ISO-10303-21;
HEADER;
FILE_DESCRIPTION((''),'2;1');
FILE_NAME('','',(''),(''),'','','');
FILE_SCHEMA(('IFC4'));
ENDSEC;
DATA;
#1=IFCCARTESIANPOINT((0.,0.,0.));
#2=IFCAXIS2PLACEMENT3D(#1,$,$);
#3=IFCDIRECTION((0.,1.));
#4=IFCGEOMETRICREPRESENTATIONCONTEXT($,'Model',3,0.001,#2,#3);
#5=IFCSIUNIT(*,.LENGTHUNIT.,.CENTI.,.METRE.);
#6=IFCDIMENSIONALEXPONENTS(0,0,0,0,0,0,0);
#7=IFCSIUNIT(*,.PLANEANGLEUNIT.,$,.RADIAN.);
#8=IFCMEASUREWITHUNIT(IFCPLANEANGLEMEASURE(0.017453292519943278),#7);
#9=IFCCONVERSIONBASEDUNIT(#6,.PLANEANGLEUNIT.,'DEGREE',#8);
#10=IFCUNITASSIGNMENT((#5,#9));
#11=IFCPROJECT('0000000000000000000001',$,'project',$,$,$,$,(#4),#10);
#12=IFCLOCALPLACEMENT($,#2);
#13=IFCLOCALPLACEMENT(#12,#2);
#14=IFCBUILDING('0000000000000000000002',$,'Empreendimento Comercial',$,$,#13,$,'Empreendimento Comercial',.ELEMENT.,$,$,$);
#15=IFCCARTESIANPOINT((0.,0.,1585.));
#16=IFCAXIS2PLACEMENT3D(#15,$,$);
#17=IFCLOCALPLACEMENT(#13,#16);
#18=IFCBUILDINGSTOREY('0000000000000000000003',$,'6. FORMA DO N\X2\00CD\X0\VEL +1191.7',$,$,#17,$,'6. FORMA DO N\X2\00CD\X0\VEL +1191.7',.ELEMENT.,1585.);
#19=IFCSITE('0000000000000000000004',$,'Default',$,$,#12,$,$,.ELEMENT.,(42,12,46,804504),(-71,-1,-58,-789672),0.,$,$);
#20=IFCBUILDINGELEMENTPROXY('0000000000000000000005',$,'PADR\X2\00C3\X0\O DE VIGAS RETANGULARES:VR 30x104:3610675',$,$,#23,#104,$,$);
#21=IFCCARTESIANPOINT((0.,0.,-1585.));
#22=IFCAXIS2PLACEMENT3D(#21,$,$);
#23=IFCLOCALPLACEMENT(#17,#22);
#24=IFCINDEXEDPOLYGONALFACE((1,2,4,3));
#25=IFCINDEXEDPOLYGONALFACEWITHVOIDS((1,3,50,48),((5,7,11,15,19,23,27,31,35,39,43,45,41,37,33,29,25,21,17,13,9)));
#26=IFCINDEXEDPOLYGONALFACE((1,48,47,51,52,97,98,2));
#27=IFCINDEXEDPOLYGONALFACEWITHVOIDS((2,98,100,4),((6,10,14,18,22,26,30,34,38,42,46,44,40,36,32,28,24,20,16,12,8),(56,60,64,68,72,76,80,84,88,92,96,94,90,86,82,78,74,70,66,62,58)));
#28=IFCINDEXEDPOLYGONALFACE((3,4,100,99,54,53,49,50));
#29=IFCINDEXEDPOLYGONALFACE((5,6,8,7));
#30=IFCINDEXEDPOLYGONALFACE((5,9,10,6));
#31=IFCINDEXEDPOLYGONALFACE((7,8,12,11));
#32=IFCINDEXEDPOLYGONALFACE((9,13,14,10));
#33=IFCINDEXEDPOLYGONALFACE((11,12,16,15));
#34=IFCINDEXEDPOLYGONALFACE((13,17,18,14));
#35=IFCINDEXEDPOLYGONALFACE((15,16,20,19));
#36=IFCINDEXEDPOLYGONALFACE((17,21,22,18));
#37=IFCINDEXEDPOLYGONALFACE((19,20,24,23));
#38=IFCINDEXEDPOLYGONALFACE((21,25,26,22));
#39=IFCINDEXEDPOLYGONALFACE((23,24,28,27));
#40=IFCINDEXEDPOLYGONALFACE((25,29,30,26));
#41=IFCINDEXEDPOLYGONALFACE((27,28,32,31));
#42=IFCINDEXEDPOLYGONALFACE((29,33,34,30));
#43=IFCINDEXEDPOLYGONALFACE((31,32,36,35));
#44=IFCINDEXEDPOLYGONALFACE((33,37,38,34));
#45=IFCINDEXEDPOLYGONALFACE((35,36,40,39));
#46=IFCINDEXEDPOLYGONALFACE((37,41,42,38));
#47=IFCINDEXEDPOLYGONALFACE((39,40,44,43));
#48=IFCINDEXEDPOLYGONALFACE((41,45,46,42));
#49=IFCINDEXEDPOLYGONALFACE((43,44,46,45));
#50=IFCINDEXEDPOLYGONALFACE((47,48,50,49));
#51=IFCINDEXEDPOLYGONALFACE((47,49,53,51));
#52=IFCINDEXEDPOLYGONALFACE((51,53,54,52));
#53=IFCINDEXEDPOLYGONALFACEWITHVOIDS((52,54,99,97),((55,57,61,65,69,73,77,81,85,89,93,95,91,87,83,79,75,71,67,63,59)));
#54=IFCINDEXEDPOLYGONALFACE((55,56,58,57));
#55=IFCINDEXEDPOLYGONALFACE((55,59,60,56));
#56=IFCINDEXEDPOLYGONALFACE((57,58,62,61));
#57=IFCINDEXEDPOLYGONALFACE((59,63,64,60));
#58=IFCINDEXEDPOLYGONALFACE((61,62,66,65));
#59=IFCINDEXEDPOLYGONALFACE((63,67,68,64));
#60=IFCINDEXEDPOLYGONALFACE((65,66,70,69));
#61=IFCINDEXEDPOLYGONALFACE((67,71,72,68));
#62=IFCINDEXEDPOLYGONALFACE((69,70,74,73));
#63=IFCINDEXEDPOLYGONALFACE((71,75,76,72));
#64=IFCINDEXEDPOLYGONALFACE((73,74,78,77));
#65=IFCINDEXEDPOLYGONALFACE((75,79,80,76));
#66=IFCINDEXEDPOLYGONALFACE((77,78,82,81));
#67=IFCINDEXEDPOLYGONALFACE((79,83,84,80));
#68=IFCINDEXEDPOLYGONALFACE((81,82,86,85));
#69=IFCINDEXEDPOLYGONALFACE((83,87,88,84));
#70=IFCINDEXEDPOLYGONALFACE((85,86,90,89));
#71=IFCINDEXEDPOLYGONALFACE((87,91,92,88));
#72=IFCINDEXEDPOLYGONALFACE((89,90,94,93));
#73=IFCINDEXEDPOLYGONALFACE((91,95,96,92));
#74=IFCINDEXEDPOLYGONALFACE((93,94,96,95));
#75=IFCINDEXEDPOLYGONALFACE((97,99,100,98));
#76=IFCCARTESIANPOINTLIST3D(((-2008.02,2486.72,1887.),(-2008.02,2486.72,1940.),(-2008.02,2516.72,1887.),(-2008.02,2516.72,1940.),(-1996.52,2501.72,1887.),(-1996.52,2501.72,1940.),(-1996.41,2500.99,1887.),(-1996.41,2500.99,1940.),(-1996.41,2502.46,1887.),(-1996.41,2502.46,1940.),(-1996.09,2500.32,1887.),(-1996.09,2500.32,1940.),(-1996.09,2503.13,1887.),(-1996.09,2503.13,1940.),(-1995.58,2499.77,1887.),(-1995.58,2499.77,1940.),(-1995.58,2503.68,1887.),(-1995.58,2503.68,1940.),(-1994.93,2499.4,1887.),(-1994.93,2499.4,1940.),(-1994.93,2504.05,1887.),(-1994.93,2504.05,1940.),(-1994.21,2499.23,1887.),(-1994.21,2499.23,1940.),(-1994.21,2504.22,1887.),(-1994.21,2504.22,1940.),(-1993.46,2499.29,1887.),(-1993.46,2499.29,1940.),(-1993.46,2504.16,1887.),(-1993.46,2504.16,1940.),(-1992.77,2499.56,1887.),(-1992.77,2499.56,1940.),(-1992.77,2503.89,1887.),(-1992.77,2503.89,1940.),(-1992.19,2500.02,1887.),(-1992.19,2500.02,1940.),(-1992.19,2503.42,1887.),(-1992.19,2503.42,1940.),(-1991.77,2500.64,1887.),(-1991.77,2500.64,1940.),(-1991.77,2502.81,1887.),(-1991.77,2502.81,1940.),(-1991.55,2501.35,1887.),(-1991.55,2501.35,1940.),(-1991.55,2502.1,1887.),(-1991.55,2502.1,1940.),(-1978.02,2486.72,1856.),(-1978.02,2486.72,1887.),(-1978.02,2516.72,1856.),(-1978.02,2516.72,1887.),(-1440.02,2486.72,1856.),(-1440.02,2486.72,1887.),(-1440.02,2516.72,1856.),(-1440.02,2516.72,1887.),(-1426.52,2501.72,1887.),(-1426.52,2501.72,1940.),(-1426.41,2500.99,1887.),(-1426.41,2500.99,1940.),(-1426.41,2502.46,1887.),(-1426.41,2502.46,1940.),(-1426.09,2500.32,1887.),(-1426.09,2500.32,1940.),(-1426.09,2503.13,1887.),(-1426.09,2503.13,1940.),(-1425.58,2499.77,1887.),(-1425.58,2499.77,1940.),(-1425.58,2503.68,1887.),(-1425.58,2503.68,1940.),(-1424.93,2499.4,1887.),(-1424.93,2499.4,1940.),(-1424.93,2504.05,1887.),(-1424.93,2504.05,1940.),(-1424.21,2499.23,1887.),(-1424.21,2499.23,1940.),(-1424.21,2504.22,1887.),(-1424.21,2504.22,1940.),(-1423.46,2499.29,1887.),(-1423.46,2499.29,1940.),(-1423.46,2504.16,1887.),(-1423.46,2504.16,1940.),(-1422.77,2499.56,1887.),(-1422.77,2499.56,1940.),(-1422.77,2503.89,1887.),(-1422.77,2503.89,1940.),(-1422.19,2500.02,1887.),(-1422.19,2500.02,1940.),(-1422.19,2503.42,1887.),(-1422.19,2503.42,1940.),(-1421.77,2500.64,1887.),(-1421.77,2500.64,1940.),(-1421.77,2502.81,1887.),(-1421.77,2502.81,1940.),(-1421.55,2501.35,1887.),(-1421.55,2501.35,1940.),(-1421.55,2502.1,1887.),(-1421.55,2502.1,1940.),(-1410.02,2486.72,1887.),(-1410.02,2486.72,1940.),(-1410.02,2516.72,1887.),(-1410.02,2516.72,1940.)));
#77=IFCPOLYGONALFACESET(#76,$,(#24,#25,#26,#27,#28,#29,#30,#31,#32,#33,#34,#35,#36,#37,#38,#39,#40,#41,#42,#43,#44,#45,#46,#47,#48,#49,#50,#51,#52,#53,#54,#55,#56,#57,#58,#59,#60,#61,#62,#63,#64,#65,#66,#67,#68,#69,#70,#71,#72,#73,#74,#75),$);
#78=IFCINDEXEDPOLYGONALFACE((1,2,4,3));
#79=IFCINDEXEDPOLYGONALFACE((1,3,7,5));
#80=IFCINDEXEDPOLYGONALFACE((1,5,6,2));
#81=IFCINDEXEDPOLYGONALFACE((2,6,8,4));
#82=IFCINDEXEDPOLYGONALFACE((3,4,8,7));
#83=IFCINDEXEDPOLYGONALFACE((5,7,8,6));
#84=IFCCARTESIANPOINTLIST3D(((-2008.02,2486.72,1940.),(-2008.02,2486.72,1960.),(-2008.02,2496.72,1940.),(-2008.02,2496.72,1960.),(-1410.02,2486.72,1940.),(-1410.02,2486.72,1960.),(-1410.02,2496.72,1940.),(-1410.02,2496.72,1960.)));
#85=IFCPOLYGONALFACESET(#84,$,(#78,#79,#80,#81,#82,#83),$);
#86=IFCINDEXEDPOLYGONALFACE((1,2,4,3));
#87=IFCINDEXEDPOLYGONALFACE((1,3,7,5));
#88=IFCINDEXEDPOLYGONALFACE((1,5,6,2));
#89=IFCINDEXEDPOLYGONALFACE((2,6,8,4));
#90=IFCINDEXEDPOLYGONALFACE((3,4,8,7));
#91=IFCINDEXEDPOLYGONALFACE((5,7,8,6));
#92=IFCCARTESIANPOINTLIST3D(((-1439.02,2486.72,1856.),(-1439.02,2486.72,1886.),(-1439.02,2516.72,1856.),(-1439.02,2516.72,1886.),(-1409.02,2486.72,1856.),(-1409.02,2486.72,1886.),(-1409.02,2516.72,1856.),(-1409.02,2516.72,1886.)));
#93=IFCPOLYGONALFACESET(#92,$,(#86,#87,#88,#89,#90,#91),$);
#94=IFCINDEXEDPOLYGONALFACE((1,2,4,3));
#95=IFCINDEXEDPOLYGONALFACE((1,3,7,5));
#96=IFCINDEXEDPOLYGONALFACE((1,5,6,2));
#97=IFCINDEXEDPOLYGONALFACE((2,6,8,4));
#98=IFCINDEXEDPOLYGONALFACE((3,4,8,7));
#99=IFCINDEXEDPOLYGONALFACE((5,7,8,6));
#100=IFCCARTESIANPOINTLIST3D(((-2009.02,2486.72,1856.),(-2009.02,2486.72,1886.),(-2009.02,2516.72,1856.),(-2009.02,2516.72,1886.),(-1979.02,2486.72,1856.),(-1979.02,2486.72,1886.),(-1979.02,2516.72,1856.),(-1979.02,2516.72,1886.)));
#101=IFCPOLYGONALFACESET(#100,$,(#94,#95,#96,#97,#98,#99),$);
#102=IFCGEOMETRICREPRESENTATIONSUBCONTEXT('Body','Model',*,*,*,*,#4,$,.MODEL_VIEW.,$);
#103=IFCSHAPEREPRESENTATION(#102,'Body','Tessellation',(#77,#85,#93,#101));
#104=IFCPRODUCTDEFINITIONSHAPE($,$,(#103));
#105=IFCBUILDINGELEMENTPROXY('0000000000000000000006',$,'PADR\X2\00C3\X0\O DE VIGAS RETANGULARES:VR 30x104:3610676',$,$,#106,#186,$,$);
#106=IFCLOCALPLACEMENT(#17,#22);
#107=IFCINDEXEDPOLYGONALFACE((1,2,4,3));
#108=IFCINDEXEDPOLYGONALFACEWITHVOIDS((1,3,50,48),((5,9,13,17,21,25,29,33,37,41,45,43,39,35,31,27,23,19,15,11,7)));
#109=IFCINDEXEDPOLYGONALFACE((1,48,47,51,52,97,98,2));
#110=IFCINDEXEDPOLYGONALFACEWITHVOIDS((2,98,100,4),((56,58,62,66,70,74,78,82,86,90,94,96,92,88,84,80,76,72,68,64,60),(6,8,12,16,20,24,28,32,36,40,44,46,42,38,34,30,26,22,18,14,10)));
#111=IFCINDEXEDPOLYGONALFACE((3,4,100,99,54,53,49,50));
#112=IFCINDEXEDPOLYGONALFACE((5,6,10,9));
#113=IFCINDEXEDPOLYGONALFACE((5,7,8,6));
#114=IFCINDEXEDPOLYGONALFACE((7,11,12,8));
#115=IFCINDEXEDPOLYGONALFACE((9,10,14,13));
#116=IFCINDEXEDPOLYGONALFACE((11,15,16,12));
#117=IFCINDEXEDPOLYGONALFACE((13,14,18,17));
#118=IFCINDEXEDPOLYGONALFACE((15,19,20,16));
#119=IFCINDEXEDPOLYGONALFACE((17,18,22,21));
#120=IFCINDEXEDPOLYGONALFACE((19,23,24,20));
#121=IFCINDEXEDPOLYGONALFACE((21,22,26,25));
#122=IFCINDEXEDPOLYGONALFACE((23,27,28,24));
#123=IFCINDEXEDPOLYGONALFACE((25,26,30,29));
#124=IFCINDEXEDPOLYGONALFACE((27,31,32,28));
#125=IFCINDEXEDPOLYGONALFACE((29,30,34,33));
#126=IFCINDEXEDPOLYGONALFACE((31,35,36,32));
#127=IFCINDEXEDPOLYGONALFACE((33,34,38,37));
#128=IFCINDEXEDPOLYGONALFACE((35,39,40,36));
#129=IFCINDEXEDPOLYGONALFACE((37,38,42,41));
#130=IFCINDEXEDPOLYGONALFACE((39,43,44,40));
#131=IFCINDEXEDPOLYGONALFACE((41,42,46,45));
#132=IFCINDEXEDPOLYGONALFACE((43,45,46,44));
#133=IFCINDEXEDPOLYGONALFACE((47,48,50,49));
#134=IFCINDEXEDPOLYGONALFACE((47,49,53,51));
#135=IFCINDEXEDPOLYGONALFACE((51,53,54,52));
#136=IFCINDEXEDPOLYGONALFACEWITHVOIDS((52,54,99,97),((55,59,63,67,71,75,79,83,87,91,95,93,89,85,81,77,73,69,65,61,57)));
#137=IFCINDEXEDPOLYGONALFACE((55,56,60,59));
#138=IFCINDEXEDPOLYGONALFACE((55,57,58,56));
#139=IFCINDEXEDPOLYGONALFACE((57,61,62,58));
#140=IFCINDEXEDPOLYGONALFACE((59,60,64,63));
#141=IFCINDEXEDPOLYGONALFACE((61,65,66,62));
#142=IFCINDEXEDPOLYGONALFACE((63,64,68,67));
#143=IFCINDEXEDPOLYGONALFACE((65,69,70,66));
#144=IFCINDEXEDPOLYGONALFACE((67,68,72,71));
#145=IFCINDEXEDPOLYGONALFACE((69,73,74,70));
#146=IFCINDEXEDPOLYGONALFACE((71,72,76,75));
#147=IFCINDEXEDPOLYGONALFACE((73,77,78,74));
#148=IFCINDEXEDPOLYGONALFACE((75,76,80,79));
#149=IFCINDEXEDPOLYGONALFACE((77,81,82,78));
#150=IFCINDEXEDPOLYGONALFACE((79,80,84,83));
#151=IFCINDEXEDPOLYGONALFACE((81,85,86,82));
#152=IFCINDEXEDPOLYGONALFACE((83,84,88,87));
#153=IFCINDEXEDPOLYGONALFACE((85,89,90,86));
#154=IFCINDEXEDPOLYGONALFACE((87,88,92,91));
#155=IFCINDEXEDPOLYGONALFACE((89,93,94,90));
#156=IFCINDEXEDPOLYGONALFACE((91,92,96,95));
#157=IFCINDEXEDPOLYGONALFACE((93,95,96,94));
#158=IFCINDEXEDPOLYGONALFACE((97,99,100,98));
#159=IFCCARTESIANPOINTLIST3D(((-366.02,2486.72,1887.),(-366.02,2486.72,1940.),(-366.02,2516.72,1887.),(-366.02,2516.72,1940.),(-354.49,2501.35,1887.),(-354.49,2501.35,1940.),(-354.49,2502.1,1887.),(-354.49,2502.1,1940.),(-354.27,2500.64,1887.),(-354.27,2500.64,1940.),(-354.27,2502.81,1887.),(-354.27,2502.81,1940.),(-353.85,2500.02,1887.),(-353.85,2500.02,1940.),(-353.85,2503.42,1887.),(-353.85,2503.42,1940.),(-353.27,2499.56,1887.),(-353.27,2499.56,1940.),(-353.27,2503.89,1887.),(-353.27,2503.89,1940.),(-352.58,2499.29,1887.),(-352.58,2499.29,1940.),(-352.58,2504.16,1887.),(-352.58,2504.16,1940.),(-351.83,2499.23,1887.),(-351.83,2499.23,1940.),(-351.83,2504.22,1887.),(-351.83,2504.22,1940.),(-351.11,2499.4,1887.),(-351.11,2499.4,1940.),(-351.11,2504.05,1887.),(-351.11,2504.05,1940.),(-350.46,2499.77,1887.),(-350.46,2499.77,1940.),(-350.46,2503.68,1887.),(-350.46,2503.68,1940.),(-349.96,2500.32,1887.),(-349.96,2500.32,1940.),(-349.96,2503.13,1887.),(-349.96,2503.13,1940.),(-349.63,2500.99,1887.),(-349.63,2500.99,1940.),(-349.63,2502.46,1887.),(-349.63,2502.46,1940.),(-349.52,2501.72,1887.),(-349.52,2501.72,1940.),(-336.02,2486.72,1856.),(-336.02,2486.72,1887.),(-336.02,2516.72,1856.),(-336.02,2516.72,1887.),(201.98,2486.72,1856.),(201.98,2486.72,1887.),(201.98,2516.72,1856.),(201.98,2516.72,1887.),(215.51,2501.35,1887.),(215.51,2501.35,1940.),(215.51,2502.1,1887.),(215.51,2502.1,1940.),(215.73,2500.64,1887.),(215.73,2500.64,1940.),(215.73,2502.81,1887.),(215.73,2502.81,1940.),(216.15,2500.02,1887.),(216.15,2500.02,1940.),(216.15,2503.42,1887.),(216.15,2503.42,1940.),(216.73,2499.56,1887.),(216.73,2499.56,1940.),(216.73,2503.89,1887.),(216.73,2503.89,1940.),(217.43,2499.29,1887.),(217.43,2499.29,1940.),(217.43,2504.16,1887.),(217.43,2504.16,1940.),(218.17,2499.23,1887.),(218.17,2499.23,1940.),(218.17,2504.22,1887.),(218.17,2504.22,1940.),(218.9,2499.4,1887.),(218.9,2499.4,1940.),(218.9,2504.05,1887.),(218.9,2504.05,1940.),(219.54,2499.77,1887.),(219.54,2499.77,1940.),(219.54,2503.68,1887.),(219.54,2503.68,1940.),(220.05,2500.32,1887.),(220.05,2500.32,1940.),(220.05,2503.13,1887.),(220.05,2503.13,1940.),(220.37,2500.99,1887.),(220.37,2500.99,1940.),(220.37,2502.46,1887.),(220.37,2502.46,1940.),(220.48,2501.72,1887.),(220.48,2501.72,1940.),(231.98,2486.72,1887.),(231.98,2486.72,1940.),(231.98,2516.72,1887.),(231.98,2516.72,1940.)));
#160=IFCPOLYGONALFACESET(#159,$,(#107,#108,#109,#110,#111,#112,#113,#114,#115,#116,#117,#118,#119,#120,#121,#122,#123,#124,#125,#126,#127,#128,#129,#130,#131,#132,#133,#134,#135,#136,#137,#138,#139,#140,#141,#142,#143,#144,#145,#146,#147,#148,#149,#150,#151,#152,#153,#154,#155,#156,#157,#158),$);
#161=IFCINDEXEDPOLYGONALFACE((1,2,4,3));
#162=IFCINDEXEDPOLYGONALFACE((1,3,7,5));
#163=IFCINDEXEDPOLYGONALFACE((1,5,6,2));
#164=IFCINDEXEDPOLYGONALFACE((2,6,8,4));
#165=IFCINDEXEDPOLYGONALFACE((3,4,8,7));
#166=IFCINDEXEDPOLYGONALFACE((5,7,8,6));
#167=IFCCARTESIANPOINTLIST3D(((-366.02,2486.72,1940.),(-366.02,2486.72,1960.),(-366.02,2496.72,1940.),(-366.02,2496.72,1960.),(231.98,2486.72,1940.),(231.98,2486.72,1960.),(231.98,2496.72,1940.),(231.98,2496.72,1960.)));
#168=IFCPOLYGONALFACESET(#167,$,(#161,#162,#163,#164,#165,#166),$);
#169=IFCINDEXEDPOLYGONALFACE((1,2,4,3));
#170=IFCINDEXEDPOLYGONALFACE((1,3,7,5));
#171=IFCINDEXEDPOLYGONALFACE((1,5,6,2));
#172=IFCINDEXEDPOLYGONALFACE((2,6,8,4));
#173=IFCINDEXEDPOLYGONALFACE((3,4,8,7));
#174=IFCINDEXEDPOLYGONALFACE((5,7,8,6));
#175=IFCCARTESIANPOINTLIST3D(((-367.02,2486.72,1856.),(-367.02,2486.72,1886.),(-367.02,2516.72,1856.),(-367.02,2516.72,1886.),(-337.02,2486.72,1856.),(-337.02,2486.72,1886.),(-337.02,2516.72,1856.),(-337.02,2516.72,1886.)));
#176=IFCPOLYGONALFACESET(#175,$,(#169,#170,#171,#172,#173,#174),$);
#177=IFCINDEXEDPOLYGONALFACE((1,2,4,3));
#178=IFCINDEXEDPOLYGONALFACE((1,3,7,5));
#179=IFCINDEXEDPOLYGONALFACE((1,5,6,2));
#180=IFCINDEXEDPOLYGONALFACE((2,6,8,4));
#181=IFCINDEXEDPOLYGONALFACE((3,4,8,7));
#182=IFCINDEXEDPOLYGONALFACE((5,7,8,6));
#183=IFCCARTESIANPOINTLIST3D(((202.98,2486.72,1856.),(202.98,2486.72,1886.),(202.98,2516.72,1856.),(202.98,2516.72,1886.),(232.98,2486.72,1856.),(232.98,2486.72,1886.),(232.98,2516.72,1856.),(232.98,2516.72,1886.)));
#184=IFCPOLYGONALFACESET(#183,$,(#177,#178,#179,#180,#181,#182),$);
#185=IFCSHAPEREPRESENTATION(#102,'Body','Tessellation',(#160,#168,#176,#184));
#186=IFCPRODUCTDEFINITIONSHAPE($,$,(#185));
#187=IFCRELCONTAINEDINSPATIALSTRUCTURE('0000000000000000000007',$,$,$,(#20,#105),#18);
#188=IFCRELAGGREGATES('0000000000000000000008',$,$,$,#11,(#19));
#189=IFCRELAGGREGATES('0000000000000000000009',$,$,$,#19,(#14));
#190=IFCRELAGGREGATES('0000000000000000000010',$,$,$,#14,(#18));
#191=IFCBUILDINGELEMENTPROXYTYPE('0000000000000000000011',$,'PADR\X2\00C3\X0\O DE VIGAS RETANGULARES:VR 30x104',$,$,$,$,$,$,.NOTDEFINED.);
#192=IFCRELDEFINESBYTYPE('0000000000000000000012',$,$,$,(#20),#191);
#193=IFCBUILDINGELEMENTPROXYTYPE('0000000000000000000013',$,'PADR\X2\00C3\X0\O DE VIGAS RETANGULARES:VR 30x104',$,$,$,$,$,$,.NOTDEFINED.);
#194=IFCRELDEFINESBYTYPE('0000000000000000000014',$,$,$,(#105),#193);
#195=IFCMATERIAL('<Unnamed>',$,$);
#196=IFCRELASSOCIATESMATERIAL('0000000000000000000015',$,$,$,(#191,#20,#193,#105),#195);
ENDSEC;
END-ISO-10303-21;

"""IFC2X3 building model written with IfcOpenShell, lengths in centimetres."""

from ifc_helpers import new_model, entity, si_unit, converted_unit, direction, frame, frame_2d, origin, origin_2d_with_axis, place, context, subcontext, project, spatial, polyline, rectangle, circle, outline, extrude, source, transform, mapped, material, type_object, type_shapes, element, save


model = new_model("IFC2X3")

# Units and contexts
model_context = context("Model", 3, precision=0.001, world=origin(), true_north=direction((0.0, 1.0)))
body_context = subcontext(model_context, "Body", "Model", "MODEL_VIEW")
ifc_project = project(units=[si_unit("LENGTHUNIT", "METRE", prefix="CENTI"), converted_unit("PLANEANGLEUNIT", "DEGREE", entity("IfcPlaneAngleMeasure", 0.017453292519943278), si_unit("PLANEANGLEUNIT", "RADIAN"), dimensions=[0, 0, 0, 0, 0, 0, 0])], contexts=[model_context])

# Site, building, storey
site_placement = place(None, origin())
site = spatial("IfcSite", under=ifc_project, at=site_placement, Name="Default", CompositionType="ELEMENT", RefLatitude=(42, 12, 46, 804504), RefLongitude=(-71, -1, -58, -789672), RefElevation=0.0)
building_placement = place(site_placement, origin())
building = spatial("IfcBuilding", under=site, at=building_placement, Name="Empreendimento Comercial", LongName="Empreendimento Comercial", CompositionType="ELEMENT")
storey_placement = place(building_placement, frame((0.0, 0.0, 1585.0)))
storey = spatial("IfcBuildingStorey", under=building, at=storey_placement, Name="6. FORMA DO NÍVEL +1191.7", LongName="6. FORMA DO NÍVEL +1191.7", CompositionType="ELEMENT", Elevation=1585.0)

# Shared definitions
ifc_material = material(Name="<Unnamed>")

# Building element proxies, openings
building_element_proxy_type_1 = type_object("IfcBuildingElementProxyType", Name="PADRÃO DE VIGAS RETANGULARES:VR 30x104", PredefinedType="NOTDEFINED", material=ifc_material)
shared_shape_1 = source(origin(), body_context, "Body", "SweptSolid", [
    extrude(outline(polyline([(-47.5, -299.0), (5.5, -299.0), (5.5, -269.0), (36.5, -269.0), (36.5, 269.0), (5.5, 269.0), (5.5, 299.0), (-47.5, 299.0), (-47.5, -299.0)])), frame((-1709.02, 2486.72, 1892.5), z_axis=(0.0, 1.0, 0.0), x_axis=(0.0, 0.0, -1.0)), (0.0, 0.0, 1.0), 30.0),
    extrude(rectangle(XDim=598.0, YDim=10.0, at=frame_2d((0.0, 0.0), x_axis=(1.0, 0.0))), frame((-1709.02, 2491.72, 1940.0)), (0.0, 0.0, 1.0), 20.0),
    extrude(rectangle(XDim=30.0, YDim=30.0, at=frame_2d((0.0, 0.0), x_axis=(1.0, 0.0))), frame((-1424.02, 2501.72, 1856.0), z_axis=(0.0, 0.0, 1.0), x_axis=(0.0, -1.0, 0.0)), (0.0, 0.0, 1.0), 30.0),
    extrude(rectangle(XDim=30.0, YDim=30.0, at=frame_2d((0.0, 0.0), x_axis=(1.0, 0.0))), frame((-1994.02, 2501.72, 1856.0), z_axis=(0.0, 0.0, 1.0), x_axis=(0.0, -1.0, 0.0)), (0.0, 0.0, 1.0), 30.0),
])
type_shapes(building_element_proxy_type_1, [shared_shape_1])
proxy_1_placement = place(storey_placement, frame((0.0, 0.0, -1585.0)))
proxy_1 = element("IfcBuildingElementProxy", 1, at=proxy_1_placement, inside=storey, type_object=building_element_proxy_type_1, material=ifc_material, Name="PADRÃO DE VIGAS RETANGULARES:VR 30x104:3610675", context=body_context, shape_type="MappedRepresentation", body=[
    mapped(shared_shape_1, transform((0.0, 0.0, 0.0), scale=1.0)),
])
opening_1_placement = place(storey_placement, frame((0.0, 0.0, -1585.0)))
element("IfcOpeningElement", 2, at=opening_1_placement, cuts=proxy_1, ObjectType="Opening", context=body_context, shape_type="SweptSolid", body=[
    extrude(circle(Radius=2.5, at=origin_2d_with_axis()), frame((-1424.02, 2501.72, 1887.0), z_axis=(0.0, 0.0, 1.0), x_axis=(-1.0, 0.0, 0.0)), (0.0, 0.0, 1.0), 53.0),
])
opening_2_placement = place(storey_placement, frame((0.0, 0.0, -1585.0)))
element("IfcOpeningElement", 3, at=opening_2_placement, cuts=proxy_1, ObjectType="Opening", context=body_context, shape_type="SweptSolid", body=[
    extrude(circle(Radius=2.5, at=origin_2d_with_axis()), frame((-1994.02, 2501.72, 1887.0), z_axis=(0.0, 0.0, 1.0), x_axis=(-1.0, 0.0, 0.0)), (0.0, 0.0, 1.0), 53.0),
])
building_element_proxy_type_2 = type_object("IfcBuildingElementProxyType", Name="PADRÃO DE VIGAS RETANGULARES:VR 30x104", PredefinedType="NOTDEFINED", material=ifc_material)
shared_shape_2 = source(origin(), body_context, "Body", "SweptSolid", [
    extrude(outline(polyline([(-299.0, -47.5), (299.0, -47.5), (299.0, 5.5), (269.0, 5.5), (269.0, 36.5), (-269.0, 36.5), (-269.0, 5.5), (-299.0, 5.5), (-299.0, -47.5)])), frame((-67.02, 2486.72, 1892.5), z_axis=(0.0, 1.0, 0.0), x_axis=(1.0, 0.0, 0.0)), (0.0, 0.0, 1.0), 30.0),
    extrude(rectangle(XDim=10.0, YDim=598.0, at=frame_2d((0.0, 0.0), x_axis=(1.0, 0.0))), frame((-67.02, 2491.72, 1940.0), z_axis=(0.0, 0.0, 1.0), x_axis=(0.0, 1.0, 0.0)), (0.0, 0.0, 1.0), 20.0),
    extrude(rectangle(XDim=30.0, YDim=30.0, at=frame_2d((0.0, 0.0), x_axis=(1.0, 0.0))), frame((-352.02, 2501.72, 1856.0), z_axis=(0.0, 0.0, 1.0), x_axis=(-1.0, 0.0, 0.0)), (0.0, 0.0, 1.0), 30.0),
    extrude(rectangle(XDim=30.0, YDim=30.0, at=frame_2d((0.0, 0.0), x_axis=(1.0, 0.0))), frame((217.98, 2501.72, 1856.0), z_axis=(0.0, 0.0, 1.0), x_axis=(-1.0, 0.0, 0.0)), (0.0, 0.0, 1.0), 30.0),
])
type_shapes(building_element_proxy_type_2, [shared_shape_2])
proxy_2_placement = place(storey_placement, frame((0.0, 0.0, -1585.0)))
proxy_2 = element("IfcBuildingElementProxy", 4, at=proxy_2_placement, inside=storey, type_object=building_element_proxy_type_2, material=ifc_material, Name="PADRÃO DE VIGAS RETANGULARES:VR 30x104:3610676", context=body_context, shape_type="MappedRepresentation", body=[
    mapped(shared_shape_2, transform((0.0, 0.0, 0.0), scale=1.0)),
])
opening_3_placement = place(storey_placement, frame((0.0, 0.0, -1585.0)))
element("IfcOpeningElement", 5, at=opening_3_placement, cuts=proxy_2, ObjectType="Opening", context=body_context, shape_type="SweptSolid", body=[
    extrude(circle(Radius=2.5, at=origin_2d_with_axis()), frame((217.98, 2501.72, 1887.0)), (0.0, 0.0, 1.0), 53.0),
])
opening_4_placement = place(storey_placement, frame((0.0, 0.0, -1585.0)))
element("IfcOpeningElement", 6, at=opening_4_placement, cuts=proxy_2, ObjectType="Opening", context=body_context, shape_type="SweptSolid", body=[
    extrude(circle(Radius=2.5, at=origin_2d_with_axis()), frame((-352.02, 2501.72, 1887.0)), (0.0, 0.0, 1.0), 53.0),
])

save(model, "model.ifc")
